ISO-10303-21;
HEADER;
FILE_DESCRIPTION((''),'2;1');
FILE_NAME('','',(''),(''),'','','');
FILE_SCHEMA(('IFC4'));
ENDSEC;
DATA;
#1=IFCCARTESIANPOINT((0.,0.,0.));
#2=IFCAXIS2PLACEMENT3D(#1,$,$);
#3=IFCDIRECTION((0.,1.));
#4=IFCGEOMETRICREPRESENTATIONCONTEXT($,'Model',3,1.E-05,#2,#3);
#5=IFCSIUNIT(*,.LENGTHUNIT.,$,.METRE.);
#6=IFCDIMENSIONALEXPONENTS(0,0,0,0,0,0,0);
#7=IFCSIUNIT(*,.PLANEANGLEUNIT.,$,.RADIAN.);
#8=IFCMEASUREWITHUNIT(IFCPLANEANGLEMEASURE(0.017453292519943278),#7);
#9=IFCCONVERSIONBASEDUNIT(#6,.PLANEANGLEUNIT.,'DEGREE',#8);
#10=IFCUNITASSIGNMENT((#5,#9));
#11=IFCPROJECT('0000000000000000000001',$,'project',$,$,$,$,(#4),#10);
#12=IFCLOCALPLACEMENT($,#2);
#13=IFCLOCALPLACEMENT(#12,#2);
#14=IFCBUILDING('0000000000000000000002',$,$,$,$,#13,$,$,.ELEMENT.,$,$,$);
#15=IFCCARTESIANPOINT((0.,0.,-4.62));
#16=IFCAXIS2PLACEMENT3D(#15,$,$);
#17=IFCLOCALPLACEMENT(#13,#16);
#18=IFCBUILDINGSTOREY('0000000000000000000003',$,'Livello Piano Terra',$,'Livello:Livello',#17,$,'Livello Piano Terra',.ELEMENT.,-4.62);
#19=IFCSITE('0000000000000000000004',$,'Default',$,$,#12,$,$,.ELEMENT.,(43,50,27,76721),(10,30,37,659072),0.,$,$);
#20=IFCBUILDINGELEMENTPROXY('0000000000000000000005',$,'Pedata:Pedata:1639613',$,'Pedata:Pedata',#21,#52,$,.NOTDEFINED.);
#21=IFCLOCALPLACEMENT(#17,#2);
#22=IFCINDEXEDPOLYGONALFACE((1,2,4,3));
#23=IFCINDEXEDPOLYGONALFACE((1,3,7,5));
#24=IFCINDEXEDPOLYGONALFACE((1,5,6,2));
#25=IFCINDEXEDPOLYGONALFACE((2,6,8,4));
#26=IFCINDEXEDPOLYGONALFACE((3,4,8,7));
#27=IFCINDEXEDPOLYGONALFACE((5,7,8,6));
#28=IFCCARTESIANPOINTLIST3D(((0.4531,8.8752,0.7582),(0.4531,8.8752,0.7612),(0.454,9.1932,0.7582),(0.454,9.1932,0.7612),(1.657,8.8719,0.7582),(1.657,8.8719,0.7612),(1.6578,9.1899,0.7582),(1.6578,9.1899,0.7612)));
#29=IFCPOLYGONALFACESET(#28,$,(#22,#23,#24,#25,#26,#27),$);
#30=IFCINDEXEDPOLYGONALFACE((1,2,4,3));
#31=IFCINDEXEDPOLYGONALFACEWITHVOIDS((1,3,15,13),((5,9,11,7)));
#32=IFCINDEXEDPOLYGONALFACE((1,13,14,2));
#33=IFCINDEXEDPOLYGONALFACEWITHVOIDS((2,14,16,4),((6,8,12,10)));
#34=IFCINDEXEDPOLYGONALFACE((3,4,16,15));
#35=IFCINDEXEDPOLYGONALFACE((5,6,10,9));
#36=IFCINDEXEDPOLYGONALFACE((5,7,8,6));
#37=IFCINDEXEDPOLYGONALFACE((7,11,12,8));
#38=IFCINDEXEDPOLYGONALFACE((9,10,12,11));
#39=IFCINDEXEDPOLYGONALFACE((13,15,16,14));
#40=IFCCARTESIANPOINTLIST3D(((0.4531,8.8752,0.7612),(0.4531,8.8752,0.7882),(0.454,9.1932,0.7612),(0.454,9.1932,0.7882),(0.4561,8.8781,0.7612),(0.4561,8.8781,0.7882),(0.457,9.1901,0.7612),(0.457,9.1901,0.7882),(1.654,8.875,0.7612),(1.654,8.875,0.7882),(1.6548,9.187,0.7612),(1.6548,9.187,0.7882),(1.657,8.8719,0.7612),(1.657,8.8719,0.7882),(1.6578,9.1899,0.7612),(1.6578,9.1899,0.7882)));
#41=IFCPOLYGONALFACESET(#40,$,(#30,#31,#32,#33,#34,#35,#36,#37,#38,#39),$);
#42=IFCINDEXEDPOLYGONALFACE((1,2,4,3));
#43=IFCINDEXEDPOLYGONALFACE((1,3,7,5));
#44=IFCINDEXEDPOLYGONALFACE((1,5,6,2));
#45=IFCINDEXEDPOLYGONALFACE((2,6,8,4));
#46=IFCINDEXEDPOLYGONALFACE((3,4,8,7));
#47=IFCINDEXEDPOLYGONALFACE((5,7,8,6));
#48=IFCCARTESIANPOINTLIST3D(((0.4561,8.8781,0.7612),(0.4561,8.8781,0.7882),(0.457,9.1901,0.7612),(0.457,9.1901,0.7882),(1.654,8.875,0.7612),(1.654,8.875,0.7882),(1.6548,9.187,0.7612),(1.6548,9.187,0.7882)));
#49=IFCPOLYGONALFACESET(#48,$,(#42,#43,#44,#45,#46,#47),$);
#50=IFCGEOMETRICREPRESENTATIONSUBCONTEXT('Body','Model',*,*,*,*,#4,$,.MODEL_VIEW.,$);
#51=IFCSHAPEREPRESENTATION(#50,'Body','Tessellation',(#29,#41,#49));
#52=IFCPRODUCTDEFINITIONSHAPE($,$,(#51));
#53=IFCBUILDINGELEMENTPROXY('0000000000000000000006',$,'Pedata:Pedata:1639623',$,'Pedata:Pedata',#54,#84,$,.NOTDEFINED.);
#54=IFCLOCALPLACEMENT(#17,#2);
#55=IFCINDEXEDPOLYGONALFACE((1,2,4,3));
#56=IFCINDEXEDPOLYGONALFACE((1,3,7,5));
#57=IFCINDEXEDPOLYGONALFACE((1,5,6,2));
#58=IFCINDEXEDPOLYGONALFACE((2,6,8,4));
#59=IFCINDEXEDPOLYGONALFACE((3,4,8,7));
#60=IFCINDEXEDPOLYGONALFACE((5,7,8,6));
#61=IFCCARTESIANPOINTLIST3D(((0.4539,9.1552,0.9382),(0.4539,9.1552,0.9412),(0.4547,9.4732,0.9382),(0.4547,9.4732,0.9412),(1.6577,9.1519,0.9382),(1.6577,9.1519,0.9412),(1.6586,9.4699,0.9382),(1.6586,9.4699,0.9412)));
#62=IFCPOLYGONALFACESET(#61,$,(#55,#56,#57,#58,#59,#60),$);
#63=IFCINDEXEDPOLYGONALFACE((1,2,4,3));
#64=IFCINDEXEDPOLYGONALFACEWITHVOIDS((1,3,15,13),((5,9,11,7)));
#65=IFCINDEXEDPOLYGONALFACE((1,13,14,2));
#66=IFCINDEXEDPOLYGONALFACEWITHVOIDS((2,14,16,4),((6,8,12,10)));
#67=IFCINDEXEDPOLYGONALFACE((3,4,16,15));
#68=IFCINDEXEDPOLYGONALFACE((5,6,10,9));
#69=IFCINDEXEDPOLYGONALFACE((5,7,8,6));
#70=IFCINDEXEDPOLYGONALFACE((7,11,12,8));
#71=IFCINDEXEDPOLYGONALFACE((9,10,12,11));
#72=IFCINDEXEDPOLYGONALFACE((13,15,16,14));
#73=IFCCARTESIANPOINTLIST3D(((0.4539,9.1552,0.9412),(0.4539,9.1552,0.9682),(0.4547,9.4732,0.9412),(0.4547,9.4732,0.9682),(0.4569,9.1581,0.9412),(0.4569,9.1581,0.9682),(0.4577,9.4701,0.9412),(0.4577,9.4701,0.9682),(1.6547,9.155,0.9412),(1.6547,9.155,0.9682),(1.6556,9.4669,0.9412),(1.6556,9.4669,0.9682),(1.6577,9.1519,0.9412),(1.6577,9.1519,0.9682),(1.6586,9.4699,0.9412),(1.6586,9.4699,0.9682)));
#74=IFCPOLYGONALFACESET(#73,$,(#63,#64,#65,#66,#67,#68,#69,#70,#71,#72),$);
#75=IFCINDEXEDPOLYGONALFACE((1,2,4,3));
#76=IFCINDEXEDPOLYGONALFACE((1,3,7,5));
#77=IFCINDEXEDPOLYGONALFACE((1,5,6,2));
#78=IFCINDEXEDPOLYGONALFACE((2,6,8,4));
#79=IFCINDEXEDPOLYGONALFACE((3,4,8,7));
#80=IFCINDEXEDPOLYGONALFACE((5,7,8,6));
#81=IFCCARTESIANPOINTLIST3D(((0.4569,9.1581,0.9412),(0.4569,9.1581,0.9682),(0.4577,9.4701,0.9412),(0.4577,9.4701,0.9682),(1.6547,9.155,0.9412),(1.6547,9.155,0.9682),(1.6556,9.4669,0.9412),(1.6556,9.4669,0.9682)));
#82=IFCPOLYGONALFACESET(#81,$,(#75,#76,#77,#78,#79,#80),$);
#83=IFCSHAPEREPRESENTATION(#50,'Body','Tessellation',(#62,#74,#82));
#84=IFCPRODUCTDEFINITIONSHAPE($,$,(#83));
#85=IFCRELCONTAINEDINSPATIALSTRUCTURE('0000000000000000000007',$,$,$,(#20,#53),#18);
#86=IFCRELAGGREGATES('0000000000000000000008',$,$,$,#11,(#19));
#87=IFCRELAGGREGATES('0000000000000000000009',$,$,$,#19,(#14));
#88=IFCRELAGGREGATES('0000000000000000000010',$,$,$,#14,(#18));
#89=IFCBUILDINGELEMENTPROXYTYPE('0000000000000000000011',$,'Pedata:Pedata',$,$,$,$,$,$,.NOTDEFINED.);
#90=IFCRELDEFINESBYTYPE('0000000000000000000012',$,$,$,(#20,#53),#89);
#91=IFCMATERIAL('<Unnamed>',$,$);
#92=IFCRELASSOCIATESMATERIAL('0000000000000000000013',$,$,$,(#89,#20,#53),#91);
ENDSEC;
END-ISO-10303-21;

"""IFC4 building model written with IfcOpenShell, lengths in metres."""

from ifc_helpers import new_model, entity, si_unit, converted_unit, direction, frame, origin, place, context, subcontext, project, spatial, indexed_curve, outline, extrude, source, transform, mapped, material, type_object, type_shapes, element, save


model = new_model("IFC4")

# Units and contexts
model_context = context("Model", 3, precision=1e-05, world=origin(), true_north=direction((0.0, 1.0)))
body_context = subcontext(model_context, "Body", "Model", "MODEL_VIEW")
ifc_project = project(units=[si_unit("LENGTHUNIT", "METRE"), converted_unit("PLANEANGLEUNIT", "DEGREE", entity("IfcPlaneAngleMeasure", 0.017453292519943278), si_unit("PLANEANGLEUNIT", "RADIAN"), dimensions=[0, 0, 0, 0, 0, 0, 0])], contexts=[model_context])

# Site, building, storey
site_placement = place(None, origin())
site = spatial("IfcSite", under=ifc_project, at=site_placement, Name="Default", CompositionType="ELEMENT", RefLatitude=(43, 50, 27, 76721), RefLongitude=(10, 30, 37, 659072), RefElevation=0.0)
building_placement = place(site_placement, origin())
building = spatial("IfcBuilding", under=site, at=building_placement, CompositionType="ELEMENT")
storey_placement = place(building_placement, frame((0.0, 0.0, -4.62)))
storey = spatial("IfcBuildingStorey", under=building, at=storey_placement, Name="Livello Piano Terra", ObjectType="Livello:Livello", LongName="Livello Piano Terra", CompositionType="ELEMENT", Elevation=-4.62)

# Building element proxies
ifc_material_1 = material(Name="<Unnamed>")
building_element_proxy_type = type_object("IfcBuildingElementProxyType", Name="Pedata:Pedata", PredefinedType="NOTDEFINED", material=ifc_material_1)
shared_shape_1 = source(origin(), body_context, "Body", "SweptSolid", [
    extrude(outline(indexed_curve([(-0.6019, -0.159), (0.6019, -0.159), (0.6019, 0.159), (-0.6019, 0.159), (-0.6019, -0.159)], self_intersect=False)), frame((0.0, 0.0015, -0.03), z_axis=(0.0, 0.0, 1.0), x_axis=(-1.0, 0.0, 0.0)), (0.0, 0.0, 1.0), 0.003),
    extrude(outline(indexed_curve([(-0.159, -0.6019), (0.159, -0.6019), (0.159, 0.6019), (-0.159, 0.6019), (-0.159, -0.6019)], self_intersect=False), holes=[indexed_curve([(0.156, -0.5989), (-0.156, -0.5989), (-0.156, 0.5989), (0.156, 0.5989), (0.156, -0.5989)], self_intersect=False)]), frame((0.0, 0.0015, -0.027), z_axis=(0.0, 0.0, 1.0), x_axis=(0.0, 1.0, 0.0)), (0.0, 0.0, 1.0), 0.027),
    extrude(outline(indexed_curve([(-0.5989, -0.156), (0.5989, -0.156), (0.5989, 0.156), (-0.5989, 0.156), (-0.5989, -0.156)], self_intersect=False)), frame((0.0, 0.0015, -0.027), z_axis=(0.0, 0.0, 1.0), x_axis=(-1.0, 0.0, 0.0)), (0.0, 0.0, 1.0), 0.027),
])
type_shapes(building_element_proxy_type, [shared_shape_1])
for number, where, z_axis, x_axis, name in (
    (1, (1.0555, 9.031, 0.7882), (0.0, 0.0, 1.0), (0.999996, -0.002667, 0.0), "Pedata:Pedata:1639613"),
    (2, (1.0562, 9.311, 0.9682), (0.0, 0.0, 1.0), (0.999996, -0.002667, 0.0), "Pedata:Pedata:1639623"),
):
    element("IfcBuildingElementProxy", number, at=place(storey_placement, frame(where, z_axis=z_axis, x_axis=x_axis)), inside=storey, type_object=building_element_proxy_type, material=ifc_material_1, Name=name, ObjectType="Pedata:Pedata", PredefinedType="NOTDEFINED", context=body_context, shape_type="MappedRepresentation", body=[
        mapped(shared_shape_1, transform((0.0, 0.0, 0.0), scale=1.0)),
    ])

save(model, "model.ifc")
